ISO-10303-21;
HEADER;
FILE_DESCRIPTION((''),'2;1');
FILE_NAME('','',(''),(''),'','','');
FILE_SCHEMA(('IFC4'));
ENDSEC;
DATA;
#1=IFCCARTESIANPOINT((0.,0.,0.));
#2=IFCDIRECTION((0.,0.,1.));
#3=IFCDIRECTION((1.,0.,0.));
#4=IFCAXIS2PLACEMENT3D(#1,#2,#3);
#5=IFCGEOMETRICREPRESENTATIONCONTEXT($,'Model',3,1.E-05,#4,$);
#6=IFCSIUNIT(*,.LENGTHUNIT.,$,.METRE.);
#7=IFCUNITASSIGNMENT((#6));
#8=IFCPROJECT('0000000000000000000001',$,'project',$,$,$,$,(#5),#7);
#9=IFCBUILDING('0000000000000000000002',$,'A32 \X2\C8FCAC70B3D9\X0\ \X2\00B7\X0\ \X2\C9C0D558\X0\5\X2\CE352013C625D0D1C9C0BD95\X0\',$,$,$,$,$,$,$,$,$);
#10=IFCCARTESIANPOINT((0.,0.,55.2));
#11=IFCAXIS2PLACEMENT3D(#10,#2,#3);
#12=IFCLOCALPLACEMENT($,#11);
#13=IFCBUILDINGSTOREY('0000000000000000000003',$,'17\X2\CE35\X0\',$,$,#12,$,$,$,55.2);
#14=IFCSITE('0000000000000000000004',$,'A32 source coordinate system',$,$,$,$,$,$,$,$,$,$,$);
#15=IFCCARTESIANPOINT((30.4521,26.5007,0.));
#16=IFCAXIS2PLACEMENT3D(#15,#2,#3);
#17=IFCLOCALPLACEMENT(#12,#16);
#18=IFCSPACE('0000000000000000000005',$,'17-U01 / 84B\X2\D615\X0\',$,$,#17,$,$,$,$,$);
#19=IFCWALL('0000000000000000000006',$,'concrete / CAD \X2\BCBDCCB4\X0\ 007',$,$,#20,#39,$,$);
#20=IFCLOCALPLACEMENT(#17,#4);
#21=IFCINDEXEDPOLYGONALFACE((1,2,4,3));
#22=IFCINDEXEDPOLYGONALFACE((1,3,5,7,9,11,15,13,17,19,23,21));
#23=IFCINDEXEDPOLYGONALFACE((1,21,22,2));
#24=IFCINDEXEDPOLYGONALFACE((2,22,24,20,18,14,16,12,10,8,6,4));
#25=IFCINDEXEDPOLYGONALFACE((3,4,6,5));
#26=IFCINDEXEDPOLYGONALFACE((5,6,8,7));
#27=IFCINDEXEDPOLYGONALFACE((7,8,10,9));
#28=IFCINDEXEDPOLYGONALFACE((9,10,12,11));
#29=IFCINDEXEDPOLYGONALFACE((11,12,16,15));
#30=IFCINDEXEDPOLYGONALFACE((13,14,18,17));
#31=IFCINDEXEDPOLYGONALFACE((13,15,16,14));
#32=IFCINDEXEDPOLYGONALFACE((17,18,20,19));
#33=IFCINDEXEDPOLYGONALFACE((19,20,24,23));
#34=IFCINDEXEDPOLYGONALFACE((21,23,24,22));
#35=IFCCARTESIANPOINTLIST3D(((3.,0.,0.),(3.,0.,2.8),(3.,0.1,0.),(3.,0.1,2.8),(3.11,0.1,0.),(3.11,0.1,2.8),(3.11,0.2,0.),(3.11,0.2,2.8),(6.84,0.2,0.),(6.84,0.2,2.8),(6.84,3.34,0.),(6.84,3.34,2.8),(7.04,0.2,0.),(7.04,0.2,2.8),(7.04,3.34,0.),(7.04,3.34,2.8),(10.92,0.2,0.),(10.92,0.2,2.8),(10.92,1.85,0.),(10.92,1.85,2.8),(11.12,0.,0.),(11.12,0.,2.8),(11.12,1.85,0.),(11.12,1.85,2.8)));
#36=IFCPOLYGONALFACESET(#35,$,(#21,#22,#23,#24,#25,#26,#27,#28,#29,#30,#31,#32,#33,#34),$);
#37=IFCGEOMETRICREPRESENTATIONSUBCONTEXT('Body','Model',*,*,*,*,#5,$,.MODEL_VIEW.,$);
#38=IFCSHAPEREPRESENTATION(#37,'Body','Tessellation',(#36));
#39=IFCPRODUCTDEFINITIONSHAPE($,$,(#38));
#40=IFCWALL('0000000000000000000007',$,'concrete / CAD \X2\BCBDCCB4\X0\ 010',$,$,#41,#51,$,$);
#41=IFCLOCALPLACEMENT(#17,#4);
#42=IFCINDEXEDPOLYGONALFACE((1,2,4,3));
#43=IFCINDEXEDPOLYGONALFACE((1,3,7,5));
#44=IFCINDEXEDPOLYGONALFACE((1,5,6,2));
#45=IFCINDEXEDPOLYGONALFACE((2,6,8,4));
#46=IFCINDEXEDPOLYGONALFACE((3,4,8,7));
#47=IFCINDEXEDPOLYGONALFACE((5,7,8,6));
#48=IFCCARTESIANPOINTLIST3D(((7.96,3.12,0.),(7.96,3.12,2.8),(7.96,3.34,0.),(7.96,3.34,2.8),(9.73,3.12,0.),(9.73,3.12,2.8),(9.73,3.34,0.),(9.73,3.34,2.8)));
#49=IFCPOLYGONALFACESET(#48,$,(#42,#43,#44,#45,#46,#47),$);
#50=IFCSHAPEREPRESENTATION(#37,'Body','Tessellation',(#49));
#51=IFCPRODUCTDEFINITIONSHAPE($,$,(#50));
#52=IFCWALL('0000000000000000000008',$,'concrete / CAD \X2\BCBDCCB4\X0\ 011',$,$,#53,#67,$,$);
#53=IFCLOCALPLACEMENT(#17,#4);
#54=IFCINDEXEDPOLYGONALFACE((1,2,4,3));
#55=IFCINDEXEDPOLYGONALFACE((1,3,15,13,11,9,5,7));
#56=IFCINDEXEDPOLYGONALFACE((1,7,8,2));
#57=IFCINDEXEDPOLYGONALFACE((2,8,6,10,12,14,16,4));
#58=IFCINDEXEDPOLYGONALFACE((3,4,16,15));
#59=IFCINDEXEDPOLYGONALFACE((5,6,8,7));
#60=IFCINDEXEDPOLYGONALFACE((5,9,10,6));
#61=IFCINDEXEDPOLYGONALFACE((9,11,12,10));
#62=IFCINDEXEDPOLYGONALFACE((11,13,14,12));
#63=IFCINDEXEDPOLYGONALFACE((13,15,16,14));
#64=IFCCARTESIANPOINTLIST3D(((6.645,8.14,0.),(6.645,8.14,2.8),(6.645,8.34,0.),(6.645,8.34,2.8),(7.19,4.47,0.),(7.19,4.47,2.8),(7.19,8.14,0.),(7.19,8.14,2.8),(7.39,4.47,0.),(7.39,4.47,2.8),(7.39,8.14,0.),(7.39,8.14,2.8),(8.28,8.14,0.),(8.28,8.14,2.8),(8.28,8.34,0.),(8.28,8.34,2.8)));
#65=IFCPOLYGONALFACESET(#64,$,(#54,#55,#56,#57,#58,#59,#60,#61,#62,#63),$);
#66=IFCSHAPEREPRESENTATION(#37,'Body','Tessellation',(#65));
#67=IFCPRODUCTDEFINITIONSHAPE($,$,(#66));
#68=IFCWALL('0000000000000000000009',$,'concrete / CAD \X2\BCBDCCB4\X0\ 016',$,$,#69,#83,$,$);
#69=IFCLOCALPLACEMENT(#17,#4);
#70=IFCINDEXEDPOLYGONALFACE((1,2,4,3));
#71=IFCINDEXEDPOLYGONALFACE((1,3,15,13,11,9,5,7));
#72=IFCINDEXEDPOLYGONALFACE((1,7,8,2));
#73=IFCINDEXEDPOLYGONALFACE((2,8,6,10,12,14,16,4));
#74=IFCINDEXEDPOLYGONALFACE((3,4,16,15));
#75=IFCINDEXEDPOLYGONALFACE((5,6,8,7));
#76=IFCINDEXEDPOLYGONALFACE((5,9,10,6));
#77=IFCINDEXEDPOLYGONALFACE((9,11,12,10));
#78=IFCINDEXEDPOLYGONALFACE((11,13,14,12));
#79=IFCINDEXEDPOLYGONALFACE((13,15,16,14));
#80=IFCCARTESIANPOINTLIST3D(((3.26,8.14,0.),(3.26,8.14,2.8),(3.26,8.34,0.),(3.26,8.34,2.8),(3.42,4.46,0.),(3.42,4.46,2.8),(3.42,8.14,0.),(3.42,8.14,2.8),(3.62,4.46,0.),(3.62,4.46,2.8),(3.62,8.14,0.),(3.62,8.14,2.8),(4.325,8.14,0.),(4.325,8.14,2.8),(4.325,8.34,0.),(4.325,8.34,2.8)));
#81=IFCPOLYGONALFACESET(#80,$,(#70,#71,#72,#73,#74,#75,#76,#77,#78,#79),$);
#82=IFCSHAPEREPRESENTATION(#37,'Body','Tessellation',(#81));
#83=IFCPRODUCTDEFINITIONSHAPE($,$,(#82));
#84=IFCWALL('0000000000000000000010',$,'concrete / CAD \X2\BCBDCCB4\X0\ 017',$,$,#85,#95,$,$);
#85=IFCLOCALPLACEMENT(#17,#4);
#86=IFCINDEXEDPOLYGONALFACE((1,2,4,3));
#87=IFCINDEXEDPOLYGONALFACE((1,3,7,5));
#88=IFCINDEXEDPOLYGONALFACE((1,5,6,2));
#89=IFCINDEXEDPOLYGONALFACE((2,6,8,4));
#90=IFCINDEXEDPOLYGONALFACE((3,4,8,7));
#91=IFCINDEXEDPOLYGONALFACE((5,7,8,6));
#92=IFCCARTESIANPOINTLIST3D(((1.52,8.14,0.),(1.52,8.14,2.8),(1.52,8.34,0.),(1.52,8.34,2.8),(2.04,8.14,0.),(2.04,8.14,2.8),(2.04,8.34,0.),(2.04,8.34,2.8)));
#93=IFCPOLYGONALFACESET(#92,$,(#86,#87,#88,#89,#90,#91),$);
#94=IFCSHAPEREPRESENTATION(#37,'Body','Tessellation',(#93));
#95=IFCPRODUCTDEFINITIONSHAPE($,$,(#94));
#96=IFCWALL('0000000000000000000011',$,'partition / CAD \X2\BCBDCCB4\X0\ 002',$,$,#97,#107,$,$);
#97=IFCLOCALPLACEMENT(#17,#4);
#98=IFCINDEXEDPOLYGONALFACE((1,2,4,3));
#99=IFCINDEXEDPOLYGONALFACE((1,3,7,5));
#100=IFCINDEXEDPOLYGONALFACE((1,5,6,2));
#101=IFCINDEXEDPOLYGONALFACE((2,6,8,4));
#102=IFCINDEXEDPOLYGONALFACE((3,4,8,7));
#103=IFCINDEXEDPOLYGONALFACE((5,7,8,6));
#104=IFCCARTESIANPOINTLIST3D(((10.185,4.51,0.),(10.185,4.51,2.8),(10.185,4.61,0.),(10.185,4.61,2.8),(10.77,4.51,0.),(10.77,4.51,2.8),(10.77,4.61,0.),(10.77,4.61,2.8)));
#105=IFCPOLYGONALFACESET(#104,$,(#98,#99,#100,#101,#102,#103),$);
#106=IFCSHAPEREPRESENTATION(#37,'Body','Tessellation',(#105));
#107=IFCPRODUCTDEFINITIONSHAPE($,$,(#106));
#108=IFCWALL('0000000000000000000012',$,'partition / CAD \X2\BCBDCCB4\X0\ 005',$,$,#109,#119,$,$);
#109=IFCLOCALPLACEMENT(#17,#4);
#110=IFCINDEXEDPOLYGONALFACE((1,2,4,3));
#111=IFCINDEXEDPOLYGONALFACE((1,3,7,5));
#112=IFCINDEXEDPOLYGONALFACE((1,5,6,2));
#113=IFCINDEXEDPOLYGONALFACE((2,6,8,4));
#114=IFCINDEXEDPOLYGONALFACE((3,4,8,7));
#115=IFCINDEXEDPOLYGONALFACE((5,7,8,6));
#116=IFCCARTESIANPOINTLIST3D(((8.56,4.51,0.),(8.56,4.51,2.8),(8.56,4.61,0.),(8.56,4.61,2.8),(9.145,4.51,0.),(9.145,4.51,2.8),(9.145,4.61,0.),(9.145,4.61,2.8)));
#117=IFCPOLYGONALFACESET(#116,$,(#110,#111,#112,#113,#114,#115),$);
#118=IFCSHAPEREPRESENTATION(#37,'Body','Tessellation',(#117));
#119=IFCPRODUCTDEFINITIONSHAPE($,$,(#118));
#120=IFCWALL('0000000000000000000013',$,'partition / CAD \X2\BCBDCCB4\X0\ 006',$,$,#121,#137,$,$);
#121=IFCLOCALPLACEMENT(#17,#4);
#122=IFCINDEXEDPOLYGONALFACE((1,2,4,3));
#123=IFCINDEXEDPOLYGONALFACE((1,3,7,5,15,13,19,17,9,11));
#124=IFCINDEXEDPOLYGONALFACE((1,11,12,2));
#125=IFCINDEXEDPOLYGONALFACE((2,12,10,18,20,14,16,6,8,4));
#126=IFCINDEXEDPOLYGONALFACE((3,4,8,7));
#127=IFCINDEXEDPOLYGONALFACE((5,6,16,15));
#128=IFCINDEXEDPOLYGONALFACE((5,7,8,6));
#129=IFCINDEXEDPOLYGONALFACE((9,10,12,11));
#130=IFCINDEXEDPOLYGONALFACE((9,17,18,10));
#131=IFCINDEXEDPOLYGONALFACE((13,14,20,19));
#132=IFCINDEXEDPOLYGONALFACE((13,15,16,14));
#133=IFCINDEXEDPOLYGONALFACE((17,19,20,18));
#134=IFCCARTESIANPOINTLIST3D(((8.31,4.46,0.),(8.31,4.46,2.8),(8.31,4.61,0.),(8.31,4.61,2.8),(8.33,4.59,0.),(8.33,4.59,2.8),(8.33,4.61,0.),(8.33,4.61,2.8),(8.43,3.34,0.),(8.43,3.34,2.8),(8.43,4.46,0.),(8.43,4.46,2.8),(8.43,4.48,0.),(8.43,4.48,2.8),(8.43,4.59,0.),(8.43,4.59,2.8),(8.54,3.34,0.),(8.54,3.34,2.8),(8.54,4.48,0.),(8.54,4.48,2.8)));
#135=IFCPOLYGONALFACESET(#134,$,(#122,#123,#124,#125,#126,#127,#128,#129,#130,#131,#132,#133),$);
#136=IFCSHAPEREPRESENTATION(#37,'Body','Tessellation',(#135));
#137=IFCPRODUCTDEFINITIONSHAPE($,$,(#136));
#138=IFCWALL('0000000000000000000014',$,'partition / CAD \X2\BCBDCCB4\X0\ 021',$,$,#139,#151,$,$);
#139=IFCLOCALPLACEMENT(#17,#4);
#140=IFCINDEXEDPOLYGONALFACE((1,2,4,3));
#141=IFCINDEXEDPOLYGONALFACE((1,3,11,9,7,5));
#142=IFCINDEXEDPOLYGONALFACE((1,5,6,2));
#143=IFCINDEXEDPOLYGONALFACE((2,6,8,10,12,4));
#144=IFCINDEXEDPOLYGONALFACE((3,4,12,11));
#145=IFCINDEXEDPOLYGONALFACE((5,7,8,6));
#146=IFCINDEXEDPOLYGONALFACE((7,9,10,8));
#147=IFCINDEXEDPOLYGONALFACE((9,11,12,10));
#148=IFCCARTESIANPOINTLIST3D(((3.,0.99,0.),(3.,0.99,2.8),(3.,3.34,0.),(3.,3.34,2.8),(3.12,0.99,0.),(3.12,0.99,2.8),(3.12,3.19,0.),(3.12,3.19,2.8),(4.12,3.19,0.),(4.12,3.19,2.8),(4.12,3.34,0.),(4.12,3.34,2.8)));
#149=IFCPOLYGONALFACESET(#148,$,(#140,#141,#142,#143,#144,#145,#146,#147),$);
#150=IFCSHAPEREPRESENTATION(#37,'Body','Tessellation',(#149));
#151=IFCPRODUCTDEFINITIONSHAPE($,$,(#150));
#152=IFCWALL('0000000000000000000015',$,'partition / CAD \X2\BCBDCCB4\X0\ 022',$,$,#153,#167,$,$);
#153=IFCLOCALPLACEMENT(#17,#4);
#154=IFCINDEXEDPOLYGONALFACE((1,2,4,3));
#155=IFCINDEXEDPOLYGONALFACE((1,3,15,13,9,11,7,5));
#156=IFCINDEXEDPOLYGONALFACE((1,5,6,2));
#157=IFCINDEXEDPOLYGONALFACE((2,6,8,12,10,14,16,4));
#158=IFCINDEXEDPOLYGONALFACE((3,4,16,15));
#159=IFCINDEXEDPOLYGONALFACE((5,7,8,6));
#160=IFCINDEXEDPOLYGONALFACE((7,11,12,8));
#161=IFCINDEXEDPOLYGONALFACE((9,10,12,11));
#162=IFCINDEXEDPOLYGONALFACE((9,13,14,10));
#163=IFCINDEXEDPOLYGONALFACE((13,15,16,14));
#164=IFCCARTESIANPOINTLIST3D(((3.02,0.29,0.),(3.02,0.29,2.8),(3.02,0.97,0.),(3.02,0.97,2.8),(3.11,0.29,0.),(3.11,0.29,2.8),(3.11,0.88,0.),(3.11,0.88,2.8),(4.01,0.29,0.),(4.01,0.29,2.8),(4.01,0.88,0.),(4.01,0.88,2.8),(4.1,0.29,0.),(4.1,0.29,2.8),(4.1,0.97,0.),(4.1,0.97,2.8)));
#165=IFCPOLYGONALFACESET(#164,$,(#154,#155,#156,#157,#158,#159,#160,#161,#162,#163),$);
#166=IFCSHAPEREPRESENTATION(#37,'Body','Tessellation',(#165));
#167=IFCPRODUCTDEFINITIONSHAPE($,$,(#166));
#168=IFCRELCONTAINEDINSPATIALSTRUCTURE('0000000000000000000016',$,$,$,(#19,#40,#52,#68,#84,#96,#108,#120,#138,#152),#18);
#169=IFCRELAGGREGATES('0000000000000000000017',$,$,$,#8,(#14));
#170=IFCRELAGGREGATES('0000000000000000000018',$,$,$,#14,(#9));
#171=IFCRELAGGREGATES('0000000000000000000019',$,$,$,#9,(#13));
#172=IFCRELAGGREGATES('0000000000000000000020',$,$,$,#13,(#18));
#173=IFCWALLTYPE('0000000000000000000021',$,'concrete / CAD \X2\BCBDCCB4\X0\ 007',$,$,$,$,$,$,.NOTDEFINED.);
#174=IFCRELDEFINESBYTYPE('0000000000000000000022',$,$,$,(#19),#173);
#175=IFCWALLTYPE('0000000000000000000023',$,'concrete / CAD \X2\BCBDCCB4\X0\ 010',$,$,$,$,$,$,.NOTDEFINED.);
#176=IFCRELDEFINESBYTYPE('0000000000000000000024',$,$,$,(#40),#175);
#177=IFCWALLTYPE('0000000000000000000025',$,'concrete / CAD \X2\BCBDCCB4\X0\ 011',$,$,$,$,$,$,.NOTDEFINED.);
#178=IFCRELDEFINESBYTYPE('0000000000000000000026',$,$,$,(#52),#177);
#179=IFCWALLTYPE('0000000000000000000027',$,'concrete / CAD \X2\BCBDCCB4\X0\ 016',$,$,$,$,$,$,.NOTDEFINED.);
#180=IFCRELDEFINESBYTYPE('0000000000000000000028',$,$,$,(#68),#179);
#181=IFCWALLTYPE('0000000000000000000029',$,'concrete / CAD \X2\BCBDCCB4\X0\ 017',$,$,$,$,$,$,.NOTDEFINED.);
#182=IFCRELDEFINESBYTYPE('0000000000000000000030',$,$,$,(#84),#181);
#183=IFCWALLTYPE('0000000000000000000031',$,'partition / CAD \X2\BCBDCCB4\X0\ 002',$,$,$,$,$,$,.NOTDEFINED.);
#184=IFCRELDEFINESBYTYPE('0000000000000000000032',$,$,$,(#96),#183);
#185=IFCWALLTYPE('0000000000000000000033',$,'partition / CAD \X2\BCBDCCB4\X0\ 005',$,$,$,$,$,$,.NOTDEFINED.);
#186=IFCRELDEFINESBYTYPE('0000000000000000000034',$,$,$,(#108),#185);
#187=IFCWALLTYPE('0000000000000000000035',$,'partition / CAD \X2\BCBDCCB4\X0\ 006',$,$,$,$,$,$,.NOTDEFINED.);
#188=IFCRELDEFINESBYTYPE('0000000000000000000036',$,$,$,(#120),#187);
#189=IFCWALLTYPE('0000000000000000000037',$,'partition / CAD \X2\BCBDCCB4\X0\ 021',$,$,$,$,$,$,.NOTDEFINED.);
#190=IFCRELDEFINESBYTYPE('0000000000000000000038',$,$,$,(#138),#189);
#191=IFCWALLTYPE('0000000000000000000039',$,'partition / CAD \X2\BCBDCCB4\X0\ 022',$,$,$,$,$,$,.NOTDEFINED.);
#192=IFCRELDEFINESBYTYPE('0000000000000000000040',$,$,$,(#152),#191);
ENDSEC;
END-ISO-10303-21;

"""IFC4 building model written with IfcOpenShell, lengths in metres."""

from ifc_helpers import new_model, si_unit, frame, origin, origin_with_axes, place, context, subcontext, project, spatial, polyline, outline, extrude, source, transform, mapped, type_object, type_shapes, element, save


model = new_model("IFC4")

# Units and contexts
model_context = context("Model", 3, precision=1e-05, world=origin_with_axes())
body_context = subcontext(model_context, "Body", "Model", "MODEL_VIEW")
ifc_project = project(units=[si_unit("LENGTHUNIT", "METRE")], contexts=[model_context])

# Site, building, storey, space
site = spatial("IfcSite", under=ifc_project, Name="A32 source coordinate system")
building = spatial("IfcBuilding", under=site, Name="A32 주거동 · 지하5층–옥탑지붕")
storey_placement = place(None, frame((0.0, 0.0, 55.2), z_axis=(0.0, 0.0, 1.0), x_axis=(1.0, 0.0, 0.0)))
storey = spatial("IfcBuildingStorey", under=building, at=storey_placement, Name="17층", Elevation=55.2)
space_1_placement = place(storey_placement, frame((30.4521, 26.5007, 0.0), z_axis=(0.0, 0.0, 1.0), x_axis=(1.0, 0.0, 0.0)))
space_1 = spatial("IfcSpace", under=storey, at=space_1_placement, Name="17-U01 / 84B형")

# Walls
wall_type_1 = type_object("IfcWallType", Name="concrete / CAD 벽체 007", PredefinedType="NOTDEFINED")
shared_shape_1 = source(origin(), body_context, "Body", "SweptSolid", [
    extrude(outline(polyline([(3.0, 0.0), (3.0, 0.1), (3.11, 0.1), (3.11, 0.2), (6.84, 0.2), (6.84, 3.34), (7.04, 3.34), (7.04, 0.2), (10.92, 0.2), (10.92, 1.85), (11.12, 1.85), (11.12, 0.0), (3.0, 0.0)])), origin(), (0.0, 0.0, 1.0), 2.8),
])
type_shapes(wall_type_1, [shared_shape_1])
wall_1_placement = place(space_1_placement, origin_with_axes())
element("IfcWall", 1, at=wall_1_placement, inside=space_1, type_object=wall_type_1, Name="concrete / CAD 벽체 007", context=body_context, shape_type="MappedRepresentation", body=[
    mapped(shared_shape_1, transform((0.0, 0.0, 0.0), scale=1.0)),
])
wall_type_2 = type_object("IfcWallType", Name="concrete / CAD 벽체 010", PredefinedType="NOTDEFINED")
shared_shape_2 = source(origin(), body_context, "Body", "SweptSolid", [
    extrude(outline(polyline([(7.96, 3.12), (7.96, 3.34), (9.73, 3.34), (9.73, 3.12), (7.96, 3.12)])), origin(), (0.0, 0.0, 1.0), 2.8),
])
type_shapes(wall_type_2, [shared_shape_2])
wall_2_placement = place(space_1_placement, origin_with_axes())
element("IfcWall", 2, at=wall_2_placement, inside=space_1, type_object=wall_type_2, Name="concrete / CAD 벽체 010", context=body_context, shape_type="MappedRepresentation", body=[
    mapped(shared_shape_2, transform((0.0, 0.0, 0.0), scale=1.0)),
])
wall_type_3 = type_object("IfcWallType", Name="concrete / CAD 벽체 011", PredefinedType="NOTDEFINED")
shared_shape_3 = source(origin(), body_context, "Body", "SweptSolid", [
    extrude(outline(polyline([(7.19, 8.14), (6.645, 8.14), (6.645, 8.34), (8.28, 8.34), (8.28, 8.14), (7.39, 8.14), (7.39, 4.47), (7.19, 4.47), (7.19, 8.14)])), origin(), (0.0, 0.0, 1.0), 2.8),
])
type_shapes(wall_type_3, [shared_shape_3])
wall_3_placement = place(space_1_placement, origin_with_axes())
element("IfcWall", 3, at=wall_3_placement, inside=space_1, type_object=wall_type_3, Name="concrete / CAD 벽체 011", context=body_context, shape_type="MappedRepresentation", body=[
    mapped(shared_shape_3, transform((0.0, 0.0, 0.0), scale=1.0)),
])
wall_type_4 = type_object("IfcWallType", Name="concrete / CAD 벽체 016", PredefinedType="NOTDEFINED")
shared_shape_4 = source(origin(), body_context, "Body", "SweptSolid", [
    extrude(outline(polyline([(3.26, 8.14), (3.26, 8.34), (4.325, 8.34), (4.325, 8.14), (3.62, 8.14), (3.62, 4.46), (3.42, 4.46), (3.42, 8.14), (3.26, 8.14)])), origin(), (0.0, 0.0, 1.0), 2.8),
])
type_shapes(wall_type_4, [shared_shape_4])
wall_4_placement = place(space_1_placement, origin_with_axes())
element("IfcWall", 4, at=wall_4_placement, inside=space_1, type_object=wall_type_4, Name="concrete / CAD 벽체 016", context=body_context, shape_type="MappedRepresentation", body=[
    mapped(shared_shape_4, transform((0.0, 0.0, 0.0), scale=1.0)),
])
wall_type_5 = type_object("IfcWallType", Name="concrete / CAD 벽체 017", PredefinedType="NOTDEFINED")
shared_shape_5 = source(origin(), body_context, "Body", "SweptSolid", [
    extrude(outline(polyline([(1.52, 8.34), (2.04, 8.34), (2.04, 8.14), (1.52, 8.14), (1.52, 8.34)])), origin(), (0.0, 0.0, 1.0), 2.8),
])
type_shapes(wall_type_5, [shared_shape_5])
wall_5_placement = place(space_1_placement, origin_with_axes())
element("IfcWall", 5, at=wall_5_placement, inside=space_1, type_object=wall_type_5, Name="concrete / CAD 벽체 017", context=body_context, shape_type="MappedRepresentation", body=[
    mapped(shared_shape_5, transform((0.0, 0.0, 0.0), scale=1.0)),
])
wall_type_6 = type_object("IfcWallType", Name="partition / CAD 벽체 002", PredefinedType="NOTDEFINED")
shared_shape_6 = source(origin(), body_context, "Body", "SweptSolid", [
    extrude(outline(polyline([(10.185, 4.51), (10.185, 4.61), (10.77, 4.61), (10.77, 4.51), (10.185, 4.51)])), origin(), (0.0, 0.0, 1.0), 2.8),
])
type_shapes(wall_type_6, [shared_shape_6])
wall_6_placement = place(space_1_placement, origin_with_axes())
element("IfcWall", 6, at=wall_6_placement, inside=space_1, type_object=wall_type_6, Name="partition / CAD 벽체 002", context=body_context, shape_type="MappedRepresentation", body=[
    mapped(shared_shape_6, transform((0.0, 0.0, 0.0), scale=1.0)),
])
wall_type_7 = type_object("IfcWallType", Name="partition / CAD 벽체 005", PredefinedType="NOTDEFINED")
shared_shape_7 = source(origin(), body_context, "Body", "SweptSolid", [
    extrude(outline(polyline([(8.56, 4.51), (8.56, 4.61), (9.145, 4.61), (9.145, 4.51), (8.56, 4.51)])), origin(), (0.0, 0.0, 1.0), 2.8),
])
type_shapes(wall_type_7, [shared_shape_7])
wall_7_placement = place(space_1_placement, origin_with_axes())
element("IfcWall", 7, at=wall_7_placement, inside=space_1, type_object=wall_type_7, Name="partition / CAD 벽체 005", context=body_context, shape_type="MappedRepresentation", body=[
    mapped(shared_shape_7, transform((0.0, 0.0, 0.0), scale=1.0)),
])
wall_type_8 = type_object("IfcWallType", Name="partition / CAD 벽체 006", PredefinedType="NOTDEFINED")
shared_shape_8 = source(origin(), body_context, "Body", "SweptSolid", [
    extrude(outline(polyline([(8.43, 4.46), (8.31, 4.46), (8.31, 4.61), (8.33, 4.61), (8.33, 4.59), (8.43, 4.59), (8.43, 4.48), (8.54, 4.48), (8.54, 3.34), (8.43, 3.34), (8.43, 4.46)])), origin(), (0.0, 0.0, 1.0), 2.8),
])
type_shapes(wall_type_8, [shared_shape_8])
wall_8_placement = place(space_1_placement, origin_with_axes())
element("IfcWall", 8, at=wall_8_placement, inside=space_1, type_object=wall_type_8, Name="partition / CAD 벽체 006", context=body_context, shape_type="MappedRepresentation", body=[
    mapped(shared_shape_8, transform((0.0, 0.0, 0.0), scale=1.0)),
])
wall_type_9 = type_object("IfcWallType", Name="partition / CAD 벽체 021", PredefinedType="NOTDEFINED")
shared_shape_9 = source(origin(), body_context, "Body", "SweptSolid", [
    extrude(outline(polyline([(4.12, 3.34), (4.12, 3.19), (3.12, 3.19), (3.12, 0.99), (3.0, 0.99), (3.0, 3.34), (4.12, 3.34)])), origin(), (0.0, 0.0, 1.0), 2.8),
])
type_shapes(wall_type_9, [shared_shape_9])
wall_9_placement = place(space_1_placement, origin_with_axes())
element("IfcWall", 9, at=wall_9_placement, inside=space_1, type_object=wall_type_9, Name="partition / CAD 벽체 021", context=body_context, shape_type="MappedRepresentation", body=[
    mapped(shared_shape_9, transform((0.0, 0.0, 0.0), scale=1.0)),
])
wall_type_10 = type_object("IfcWallType", Name="partition / CAD 벽체 022", PredefinedType="NOTDEFINED")
shared_shape_10 = source(origin(), body_context, "Body", "SweptSolid", [
    extrude(outline(polyline([(4.1, 0.97), (4.1, 0.29), (4.01, 0.29), (4.01, 0.88), (3.11, 0.88), (3.11, 0.29), (3.02, 0.29), (3.02, 0.97), (4.1, 0.97)])), origin(), (0.0, 0.0, 1.0), 2.8),
])
type_shapes(wall_type_10, [shared_shape_10])
wall_10_placement = place(space_1_placement, origin_with_axes())
element("IfcWall", 10, at=wall_10_placement, inside=space_1, type_object=wall_type_10, Name="partition / CAD 벽체 022", context=body_context, shape_type="MappedRepresentation", body=[
    mapped(shared_shape_10, transform((0.0, 0.0, 0.0), scale=1.0)),
])

save(model, "model.ifc")
